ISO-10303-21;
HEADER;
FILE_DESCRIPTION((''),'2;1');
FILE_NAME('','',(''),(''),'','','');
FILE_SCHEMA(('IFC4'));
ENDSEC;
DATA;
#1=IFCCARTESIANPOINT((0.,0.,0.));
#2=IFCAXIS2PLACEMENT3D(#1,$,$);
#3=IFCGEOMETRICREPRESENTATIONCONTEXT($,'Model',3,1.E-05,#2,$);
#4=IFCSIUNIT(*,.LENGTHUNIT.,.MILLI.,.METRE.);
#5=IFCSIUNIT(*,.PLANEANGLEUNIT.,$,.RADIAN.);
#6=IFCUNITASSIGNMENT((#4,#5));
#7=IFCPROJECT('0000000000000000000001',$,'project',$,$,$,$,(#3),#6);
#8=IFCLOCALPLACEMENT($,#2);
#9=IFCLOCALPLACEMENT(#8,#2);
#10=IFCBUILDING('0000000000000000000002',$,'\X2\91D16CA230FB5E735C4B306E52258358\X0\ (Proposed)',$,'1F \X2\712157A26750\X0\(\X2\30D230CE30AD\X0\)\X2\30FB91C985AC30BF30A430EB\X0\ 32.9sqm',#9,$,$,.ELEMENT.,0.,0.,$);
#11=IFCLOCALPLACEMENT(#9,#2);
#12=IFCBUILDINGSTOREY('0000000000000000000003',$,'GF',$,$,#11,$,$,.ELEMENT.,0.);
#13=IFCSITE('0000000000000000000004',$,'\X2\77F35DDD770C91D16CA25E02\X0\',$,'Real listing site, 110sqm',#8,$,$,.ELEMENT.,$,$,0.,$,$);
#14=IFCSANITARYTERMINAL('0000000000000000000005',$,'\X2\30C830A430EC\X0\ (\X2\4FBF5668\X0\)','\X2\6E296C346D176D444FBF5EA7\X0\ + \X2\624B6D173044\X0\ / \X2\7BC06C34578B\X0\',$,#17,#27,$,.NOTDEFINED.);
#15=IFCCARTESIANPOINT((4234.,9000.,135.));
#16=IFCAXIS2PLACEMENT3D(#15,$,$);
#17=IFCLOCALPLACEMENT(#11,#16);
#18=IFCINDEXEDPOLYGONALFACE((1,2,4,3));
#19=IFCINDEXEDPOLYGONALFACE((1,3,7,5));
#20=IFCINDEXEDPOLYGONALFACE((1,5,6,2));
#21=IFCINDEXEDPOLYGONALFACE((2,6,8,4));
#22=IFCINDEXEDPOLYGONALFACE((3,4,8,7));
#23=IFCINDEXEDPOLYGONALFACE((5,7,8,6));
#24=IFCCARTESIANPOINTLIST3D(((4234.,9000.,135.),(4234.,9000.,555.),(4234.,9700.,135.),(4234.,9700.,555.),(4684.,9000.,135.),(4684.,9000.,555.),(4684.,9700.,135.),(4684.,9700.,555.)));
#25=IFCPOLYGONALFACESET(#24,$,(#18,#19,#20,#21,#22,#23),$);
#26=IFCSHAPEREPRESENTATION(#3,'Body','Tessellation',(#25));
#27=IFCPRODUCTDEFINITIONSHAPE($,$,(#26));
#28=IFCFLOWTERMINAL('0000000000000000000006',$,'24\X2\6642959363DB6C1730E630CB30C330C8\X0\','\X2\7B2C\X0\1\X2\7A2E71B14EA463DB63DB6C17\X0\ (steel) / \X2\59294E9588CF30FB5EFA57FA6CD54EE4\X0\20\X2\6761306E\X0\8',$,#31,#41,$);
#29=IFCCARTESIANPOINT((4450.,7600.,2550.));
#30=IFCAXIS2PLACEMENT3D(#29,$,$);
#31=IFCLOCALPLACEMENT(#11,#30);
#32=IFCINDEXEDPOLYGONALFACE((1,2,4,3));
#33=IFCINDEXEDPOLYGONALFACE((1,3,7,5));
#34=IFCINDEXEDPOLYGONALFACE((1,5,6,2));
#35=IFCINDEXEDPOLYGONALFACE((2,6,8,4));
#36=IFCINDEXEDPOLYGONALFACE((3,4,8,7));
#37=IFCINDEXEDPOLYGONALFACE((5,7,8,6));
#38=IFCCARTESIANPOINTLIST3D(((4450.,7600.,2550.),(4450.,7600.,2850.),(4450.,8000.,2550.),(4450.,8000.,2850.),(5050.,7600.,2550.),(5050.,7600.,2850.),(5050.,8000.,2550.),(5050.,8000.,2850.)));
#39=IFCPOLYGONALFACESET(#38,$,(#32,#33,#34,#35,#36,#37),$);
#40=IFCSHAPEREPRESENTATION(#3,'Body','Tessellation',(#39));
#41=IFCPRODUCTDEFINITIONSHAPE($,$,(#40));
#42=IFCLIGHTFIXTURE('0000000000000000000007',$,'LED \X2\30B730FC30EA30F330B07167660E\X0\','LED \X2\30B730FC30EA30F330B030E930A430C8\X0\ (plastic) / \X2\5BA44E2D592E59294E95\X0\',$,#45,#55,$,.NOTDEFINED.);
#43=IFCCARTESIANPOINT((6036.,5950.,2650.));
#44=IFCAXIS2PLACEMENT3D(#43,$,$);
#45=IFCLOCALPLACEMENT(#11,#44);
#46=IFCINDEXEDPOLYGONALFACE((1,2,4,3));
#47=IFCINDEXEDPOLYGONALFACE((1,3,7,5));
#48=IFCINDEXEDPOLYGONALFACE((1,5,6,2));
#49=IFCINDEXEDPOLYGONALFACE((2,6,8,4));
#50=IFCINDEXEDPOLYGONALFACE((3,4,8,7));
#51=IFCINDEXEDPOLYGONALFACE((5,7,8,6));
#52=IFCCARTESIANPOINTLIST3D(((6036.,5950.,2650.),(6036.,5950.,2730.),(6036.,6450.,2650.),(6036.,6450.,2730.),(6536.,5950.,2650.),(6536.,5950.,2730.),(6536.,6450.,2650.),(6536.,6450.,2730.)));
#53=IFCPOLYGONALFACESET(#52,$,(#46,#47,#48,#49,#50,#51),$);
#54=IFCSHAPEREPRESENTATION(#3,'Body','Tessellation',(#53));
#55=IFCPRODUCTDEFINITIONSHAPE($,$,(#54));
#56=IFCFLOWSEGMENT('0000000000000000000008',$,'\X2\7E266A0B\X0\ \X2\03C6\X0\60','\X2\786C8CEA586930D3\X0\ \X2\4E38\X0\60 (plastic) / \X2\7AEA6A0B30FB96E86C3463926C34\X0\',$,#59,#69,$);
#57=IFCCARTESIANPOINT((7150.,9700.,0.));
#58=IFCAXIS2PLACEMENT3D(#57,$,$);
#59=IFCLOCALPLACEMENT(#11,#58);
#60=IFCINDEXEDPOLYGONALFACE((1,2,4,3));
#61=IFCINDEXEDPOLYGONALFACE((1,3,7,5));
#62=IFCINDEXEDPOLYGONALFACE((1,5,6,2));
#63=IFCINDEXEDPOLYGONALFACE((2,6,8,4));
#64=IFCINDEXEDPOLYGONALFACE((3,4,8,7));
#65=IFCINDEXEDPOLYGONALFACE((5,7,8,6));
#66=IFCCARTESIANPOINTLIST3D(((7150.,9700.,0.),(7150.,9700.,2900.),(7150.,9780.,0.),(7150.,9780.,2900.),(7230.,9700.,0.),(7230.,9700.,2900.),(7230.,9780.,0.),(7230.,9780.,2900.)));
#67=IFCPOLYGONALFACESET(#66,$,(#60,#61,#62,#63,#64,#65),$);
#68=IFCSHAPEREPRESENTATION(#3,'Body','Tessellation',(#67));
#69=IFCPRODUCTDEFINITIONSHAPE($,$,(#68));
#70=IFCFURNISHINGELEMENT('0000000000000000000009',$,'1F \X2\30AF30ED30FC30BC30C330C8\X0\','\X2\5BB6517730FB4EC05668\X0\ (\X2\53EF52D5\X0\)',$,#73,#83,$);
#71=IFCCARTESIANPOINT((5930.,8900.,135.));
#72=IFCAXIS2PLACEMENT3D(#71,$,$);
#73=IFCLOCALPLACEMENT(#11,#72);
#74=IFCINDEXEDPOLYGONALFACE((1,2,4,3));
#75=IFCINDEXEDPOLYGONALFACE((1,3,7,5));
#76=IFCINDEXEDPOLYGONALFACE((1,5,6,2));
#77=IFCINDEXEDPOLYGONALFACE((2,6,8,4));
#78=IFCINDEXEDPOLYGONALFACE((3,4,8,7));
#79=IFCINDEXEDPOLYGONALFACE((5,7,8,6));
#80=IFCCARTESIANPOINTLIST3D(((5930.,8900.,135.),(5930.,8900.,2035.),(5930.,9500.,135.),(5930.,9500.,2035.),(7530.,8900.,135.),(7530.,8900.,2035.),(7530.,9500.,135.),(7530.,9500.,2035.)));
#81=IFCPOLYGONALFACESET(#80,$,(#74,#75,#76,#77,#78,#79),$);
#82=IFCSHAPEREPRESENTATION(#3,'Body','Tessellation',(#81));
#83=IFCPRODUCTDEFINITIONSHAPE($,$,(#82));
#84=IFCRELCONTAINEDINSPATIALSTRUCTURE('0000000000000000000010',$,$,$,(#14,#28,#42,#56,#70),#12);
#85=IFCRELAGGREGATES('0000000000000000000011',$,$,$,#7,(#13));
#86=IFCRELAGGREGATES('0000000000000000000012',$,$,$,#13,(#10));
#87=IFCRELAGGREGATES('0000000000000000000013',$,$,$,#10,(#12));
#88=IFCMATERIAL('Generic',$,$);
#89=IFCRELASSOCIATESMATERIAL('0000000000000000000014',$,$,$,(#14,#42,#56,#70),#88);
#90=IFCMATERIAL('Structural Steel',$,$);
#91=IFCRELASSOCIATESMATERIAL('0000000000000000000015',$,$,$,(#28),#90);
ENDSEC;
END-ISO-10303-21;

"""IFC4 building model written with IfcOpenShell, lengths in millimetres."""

from ifc_helpers import new_model, si_unit, frame, frame_2d, origin, place, context, project, spatial, rectangle, extrude, material, element, save


model = new_model("IFC4")

# Units and contexts
model_context = context("Model", 3, precision=1e-05, world=origin())
ifc_project = project(units=[si_unit("LENGTHUNIT", "METRE", prefix="MILLI"), si_unit("PLANEANGLEUNIT", "RADIAN")], contexts=[model_context])

# Site, building, storey
site_placement = place(None, origin())
site = spatial("IfcSite", under=ifc_project, at=site_placement, Name="石川県金沢市", ObjectType="Real listing site, 110sqm", CompositionType="ELEMENT", RefElevation=0.0)
building_placement = place(site_placement, origin())
building = spatial("IfcBuilding", under=site, at=building_placement, Name="金沢・平屋の別荘 (Proposed)", ObjectType="1F 無垢材(ヒノキ)・釉薬タイル 32.9sqm", CompositionType="ELEMENT", ElevationOfRefHeight=0.0, ElevationOfTerrain=0.0)
storey_placement = place(building_placement, origin())
storey = spatial("IfcBuildingStorey", under=building, at=storey_placement, Name="GF", CompositionType="ELEMENT", Elevation=0.0)

# Shared definitions
ifc_material_1 = material(Name="Generic")

# Sanitary terminal
sanitary_terminal_placement = place(storey_placement, frame((4234.0, 9000.0, 135.0)))
element("IfcSanitaryTerminal", 1, at=sanitary_terminal_placement, inside=storey, material=ifc_material_1, Name="トイレ (便器)", Description="温水洗浄便座 + 手洗い / 節水型", PredefinedType="NOTDEFINED", context=model_context, shape_type="SweptSolid", body=[
    extrude(rectangle(XDim=450.0, YDim=700.0, at=frame_2d((225.0, 350.0))), frame((4234.0, 9000.0, 135.0)), (0.0, 0.0, 1.0), 420.0),
])

# Flow terminal
ifc_material_2 = material(Name="Structural Steel")
flow_terminal_placement = place(storey_placement, frame((4450.0, 7600.0, 2550.0)))
element("IfcFlowTerminal", 2, at=flow_terminal_placement, inside=storey, material=ifc_material_2, Name="24時間換気ユニット", Description="第1種熱交換換気 (steel) / 天井裏・建基法令20条の8", context=model_context, shape_type="SweptSolid", body=[
    extrude(rectangle(XDim=600.0, YDim=400.0, at=frame_2d((300.0, 200.0))), frame((4450.0, 7600.0, 2550.0)), (0.0, 0.0, 1.0), 300.0),
])

# Light fixture
light_fixture_placement = place(storey_placement, frame((6036.0, 5950.0, 2650.0)))
element("IfcLightFixture", 3, at=light_fixture_placement, inside=storey, material=ifc_material_1, Name="LED シーリング照明", Description="LED シーリングライト (plastic) / 室中央天井", PredefinedType="NOTDEFINED", context=model_context, shape_type="SweptSolid", body=[
    extrude(rectangle(XDim=500.0, YDim=500.0, at=frame_2d((250.0, 250.0))), frame((6036.0, 5950.0, 2650.0)), (0.0, 0.0, 1.0), 80.0),
])

# Flow segment
flow_segment_placement = place(storey_placement, frame((7150.0, 9700.0, 0.0)))
element("IfcFlowSegment", 4, at=flow_segment_placement, inside=storey, material=ifc_material_1, Name="縦樋 φ60", Description="硬質塩ビ 丸60 (plastic) / 竪樋・雨水排水", context=model_context, shape_type="SweptSolid", body=[
    extrude(rectangle(XDim=80.0, YDim=80.0, at=frame_2d((40.0, 40.0))), frame((7150.0, 9700.0, 0.0)), (0.0, 0.0, 1.0), 2900.0),
])

# Furnishing element
furnishing_placement = place(storey_placement, frame((5930.0, 8900.0, 135.0)))
element("IfcFurnishingElement", 5, at=furnishing_placement, inside=storey, material=ifc_material_1, Name="1F クローゼット", Description="家具・什器 (可動)", context=model_context, shape_type="SweptSolid", body=[
    extrude(rectangle(XDim=1600.0, YDim=600.0, at=frame_2d((800.0, 300.0))), frame((5930.0, 8900.0, 135.0)), (0.0, 0.0, 1.0), 1900.0),
])

save(model, "model.ifc")
